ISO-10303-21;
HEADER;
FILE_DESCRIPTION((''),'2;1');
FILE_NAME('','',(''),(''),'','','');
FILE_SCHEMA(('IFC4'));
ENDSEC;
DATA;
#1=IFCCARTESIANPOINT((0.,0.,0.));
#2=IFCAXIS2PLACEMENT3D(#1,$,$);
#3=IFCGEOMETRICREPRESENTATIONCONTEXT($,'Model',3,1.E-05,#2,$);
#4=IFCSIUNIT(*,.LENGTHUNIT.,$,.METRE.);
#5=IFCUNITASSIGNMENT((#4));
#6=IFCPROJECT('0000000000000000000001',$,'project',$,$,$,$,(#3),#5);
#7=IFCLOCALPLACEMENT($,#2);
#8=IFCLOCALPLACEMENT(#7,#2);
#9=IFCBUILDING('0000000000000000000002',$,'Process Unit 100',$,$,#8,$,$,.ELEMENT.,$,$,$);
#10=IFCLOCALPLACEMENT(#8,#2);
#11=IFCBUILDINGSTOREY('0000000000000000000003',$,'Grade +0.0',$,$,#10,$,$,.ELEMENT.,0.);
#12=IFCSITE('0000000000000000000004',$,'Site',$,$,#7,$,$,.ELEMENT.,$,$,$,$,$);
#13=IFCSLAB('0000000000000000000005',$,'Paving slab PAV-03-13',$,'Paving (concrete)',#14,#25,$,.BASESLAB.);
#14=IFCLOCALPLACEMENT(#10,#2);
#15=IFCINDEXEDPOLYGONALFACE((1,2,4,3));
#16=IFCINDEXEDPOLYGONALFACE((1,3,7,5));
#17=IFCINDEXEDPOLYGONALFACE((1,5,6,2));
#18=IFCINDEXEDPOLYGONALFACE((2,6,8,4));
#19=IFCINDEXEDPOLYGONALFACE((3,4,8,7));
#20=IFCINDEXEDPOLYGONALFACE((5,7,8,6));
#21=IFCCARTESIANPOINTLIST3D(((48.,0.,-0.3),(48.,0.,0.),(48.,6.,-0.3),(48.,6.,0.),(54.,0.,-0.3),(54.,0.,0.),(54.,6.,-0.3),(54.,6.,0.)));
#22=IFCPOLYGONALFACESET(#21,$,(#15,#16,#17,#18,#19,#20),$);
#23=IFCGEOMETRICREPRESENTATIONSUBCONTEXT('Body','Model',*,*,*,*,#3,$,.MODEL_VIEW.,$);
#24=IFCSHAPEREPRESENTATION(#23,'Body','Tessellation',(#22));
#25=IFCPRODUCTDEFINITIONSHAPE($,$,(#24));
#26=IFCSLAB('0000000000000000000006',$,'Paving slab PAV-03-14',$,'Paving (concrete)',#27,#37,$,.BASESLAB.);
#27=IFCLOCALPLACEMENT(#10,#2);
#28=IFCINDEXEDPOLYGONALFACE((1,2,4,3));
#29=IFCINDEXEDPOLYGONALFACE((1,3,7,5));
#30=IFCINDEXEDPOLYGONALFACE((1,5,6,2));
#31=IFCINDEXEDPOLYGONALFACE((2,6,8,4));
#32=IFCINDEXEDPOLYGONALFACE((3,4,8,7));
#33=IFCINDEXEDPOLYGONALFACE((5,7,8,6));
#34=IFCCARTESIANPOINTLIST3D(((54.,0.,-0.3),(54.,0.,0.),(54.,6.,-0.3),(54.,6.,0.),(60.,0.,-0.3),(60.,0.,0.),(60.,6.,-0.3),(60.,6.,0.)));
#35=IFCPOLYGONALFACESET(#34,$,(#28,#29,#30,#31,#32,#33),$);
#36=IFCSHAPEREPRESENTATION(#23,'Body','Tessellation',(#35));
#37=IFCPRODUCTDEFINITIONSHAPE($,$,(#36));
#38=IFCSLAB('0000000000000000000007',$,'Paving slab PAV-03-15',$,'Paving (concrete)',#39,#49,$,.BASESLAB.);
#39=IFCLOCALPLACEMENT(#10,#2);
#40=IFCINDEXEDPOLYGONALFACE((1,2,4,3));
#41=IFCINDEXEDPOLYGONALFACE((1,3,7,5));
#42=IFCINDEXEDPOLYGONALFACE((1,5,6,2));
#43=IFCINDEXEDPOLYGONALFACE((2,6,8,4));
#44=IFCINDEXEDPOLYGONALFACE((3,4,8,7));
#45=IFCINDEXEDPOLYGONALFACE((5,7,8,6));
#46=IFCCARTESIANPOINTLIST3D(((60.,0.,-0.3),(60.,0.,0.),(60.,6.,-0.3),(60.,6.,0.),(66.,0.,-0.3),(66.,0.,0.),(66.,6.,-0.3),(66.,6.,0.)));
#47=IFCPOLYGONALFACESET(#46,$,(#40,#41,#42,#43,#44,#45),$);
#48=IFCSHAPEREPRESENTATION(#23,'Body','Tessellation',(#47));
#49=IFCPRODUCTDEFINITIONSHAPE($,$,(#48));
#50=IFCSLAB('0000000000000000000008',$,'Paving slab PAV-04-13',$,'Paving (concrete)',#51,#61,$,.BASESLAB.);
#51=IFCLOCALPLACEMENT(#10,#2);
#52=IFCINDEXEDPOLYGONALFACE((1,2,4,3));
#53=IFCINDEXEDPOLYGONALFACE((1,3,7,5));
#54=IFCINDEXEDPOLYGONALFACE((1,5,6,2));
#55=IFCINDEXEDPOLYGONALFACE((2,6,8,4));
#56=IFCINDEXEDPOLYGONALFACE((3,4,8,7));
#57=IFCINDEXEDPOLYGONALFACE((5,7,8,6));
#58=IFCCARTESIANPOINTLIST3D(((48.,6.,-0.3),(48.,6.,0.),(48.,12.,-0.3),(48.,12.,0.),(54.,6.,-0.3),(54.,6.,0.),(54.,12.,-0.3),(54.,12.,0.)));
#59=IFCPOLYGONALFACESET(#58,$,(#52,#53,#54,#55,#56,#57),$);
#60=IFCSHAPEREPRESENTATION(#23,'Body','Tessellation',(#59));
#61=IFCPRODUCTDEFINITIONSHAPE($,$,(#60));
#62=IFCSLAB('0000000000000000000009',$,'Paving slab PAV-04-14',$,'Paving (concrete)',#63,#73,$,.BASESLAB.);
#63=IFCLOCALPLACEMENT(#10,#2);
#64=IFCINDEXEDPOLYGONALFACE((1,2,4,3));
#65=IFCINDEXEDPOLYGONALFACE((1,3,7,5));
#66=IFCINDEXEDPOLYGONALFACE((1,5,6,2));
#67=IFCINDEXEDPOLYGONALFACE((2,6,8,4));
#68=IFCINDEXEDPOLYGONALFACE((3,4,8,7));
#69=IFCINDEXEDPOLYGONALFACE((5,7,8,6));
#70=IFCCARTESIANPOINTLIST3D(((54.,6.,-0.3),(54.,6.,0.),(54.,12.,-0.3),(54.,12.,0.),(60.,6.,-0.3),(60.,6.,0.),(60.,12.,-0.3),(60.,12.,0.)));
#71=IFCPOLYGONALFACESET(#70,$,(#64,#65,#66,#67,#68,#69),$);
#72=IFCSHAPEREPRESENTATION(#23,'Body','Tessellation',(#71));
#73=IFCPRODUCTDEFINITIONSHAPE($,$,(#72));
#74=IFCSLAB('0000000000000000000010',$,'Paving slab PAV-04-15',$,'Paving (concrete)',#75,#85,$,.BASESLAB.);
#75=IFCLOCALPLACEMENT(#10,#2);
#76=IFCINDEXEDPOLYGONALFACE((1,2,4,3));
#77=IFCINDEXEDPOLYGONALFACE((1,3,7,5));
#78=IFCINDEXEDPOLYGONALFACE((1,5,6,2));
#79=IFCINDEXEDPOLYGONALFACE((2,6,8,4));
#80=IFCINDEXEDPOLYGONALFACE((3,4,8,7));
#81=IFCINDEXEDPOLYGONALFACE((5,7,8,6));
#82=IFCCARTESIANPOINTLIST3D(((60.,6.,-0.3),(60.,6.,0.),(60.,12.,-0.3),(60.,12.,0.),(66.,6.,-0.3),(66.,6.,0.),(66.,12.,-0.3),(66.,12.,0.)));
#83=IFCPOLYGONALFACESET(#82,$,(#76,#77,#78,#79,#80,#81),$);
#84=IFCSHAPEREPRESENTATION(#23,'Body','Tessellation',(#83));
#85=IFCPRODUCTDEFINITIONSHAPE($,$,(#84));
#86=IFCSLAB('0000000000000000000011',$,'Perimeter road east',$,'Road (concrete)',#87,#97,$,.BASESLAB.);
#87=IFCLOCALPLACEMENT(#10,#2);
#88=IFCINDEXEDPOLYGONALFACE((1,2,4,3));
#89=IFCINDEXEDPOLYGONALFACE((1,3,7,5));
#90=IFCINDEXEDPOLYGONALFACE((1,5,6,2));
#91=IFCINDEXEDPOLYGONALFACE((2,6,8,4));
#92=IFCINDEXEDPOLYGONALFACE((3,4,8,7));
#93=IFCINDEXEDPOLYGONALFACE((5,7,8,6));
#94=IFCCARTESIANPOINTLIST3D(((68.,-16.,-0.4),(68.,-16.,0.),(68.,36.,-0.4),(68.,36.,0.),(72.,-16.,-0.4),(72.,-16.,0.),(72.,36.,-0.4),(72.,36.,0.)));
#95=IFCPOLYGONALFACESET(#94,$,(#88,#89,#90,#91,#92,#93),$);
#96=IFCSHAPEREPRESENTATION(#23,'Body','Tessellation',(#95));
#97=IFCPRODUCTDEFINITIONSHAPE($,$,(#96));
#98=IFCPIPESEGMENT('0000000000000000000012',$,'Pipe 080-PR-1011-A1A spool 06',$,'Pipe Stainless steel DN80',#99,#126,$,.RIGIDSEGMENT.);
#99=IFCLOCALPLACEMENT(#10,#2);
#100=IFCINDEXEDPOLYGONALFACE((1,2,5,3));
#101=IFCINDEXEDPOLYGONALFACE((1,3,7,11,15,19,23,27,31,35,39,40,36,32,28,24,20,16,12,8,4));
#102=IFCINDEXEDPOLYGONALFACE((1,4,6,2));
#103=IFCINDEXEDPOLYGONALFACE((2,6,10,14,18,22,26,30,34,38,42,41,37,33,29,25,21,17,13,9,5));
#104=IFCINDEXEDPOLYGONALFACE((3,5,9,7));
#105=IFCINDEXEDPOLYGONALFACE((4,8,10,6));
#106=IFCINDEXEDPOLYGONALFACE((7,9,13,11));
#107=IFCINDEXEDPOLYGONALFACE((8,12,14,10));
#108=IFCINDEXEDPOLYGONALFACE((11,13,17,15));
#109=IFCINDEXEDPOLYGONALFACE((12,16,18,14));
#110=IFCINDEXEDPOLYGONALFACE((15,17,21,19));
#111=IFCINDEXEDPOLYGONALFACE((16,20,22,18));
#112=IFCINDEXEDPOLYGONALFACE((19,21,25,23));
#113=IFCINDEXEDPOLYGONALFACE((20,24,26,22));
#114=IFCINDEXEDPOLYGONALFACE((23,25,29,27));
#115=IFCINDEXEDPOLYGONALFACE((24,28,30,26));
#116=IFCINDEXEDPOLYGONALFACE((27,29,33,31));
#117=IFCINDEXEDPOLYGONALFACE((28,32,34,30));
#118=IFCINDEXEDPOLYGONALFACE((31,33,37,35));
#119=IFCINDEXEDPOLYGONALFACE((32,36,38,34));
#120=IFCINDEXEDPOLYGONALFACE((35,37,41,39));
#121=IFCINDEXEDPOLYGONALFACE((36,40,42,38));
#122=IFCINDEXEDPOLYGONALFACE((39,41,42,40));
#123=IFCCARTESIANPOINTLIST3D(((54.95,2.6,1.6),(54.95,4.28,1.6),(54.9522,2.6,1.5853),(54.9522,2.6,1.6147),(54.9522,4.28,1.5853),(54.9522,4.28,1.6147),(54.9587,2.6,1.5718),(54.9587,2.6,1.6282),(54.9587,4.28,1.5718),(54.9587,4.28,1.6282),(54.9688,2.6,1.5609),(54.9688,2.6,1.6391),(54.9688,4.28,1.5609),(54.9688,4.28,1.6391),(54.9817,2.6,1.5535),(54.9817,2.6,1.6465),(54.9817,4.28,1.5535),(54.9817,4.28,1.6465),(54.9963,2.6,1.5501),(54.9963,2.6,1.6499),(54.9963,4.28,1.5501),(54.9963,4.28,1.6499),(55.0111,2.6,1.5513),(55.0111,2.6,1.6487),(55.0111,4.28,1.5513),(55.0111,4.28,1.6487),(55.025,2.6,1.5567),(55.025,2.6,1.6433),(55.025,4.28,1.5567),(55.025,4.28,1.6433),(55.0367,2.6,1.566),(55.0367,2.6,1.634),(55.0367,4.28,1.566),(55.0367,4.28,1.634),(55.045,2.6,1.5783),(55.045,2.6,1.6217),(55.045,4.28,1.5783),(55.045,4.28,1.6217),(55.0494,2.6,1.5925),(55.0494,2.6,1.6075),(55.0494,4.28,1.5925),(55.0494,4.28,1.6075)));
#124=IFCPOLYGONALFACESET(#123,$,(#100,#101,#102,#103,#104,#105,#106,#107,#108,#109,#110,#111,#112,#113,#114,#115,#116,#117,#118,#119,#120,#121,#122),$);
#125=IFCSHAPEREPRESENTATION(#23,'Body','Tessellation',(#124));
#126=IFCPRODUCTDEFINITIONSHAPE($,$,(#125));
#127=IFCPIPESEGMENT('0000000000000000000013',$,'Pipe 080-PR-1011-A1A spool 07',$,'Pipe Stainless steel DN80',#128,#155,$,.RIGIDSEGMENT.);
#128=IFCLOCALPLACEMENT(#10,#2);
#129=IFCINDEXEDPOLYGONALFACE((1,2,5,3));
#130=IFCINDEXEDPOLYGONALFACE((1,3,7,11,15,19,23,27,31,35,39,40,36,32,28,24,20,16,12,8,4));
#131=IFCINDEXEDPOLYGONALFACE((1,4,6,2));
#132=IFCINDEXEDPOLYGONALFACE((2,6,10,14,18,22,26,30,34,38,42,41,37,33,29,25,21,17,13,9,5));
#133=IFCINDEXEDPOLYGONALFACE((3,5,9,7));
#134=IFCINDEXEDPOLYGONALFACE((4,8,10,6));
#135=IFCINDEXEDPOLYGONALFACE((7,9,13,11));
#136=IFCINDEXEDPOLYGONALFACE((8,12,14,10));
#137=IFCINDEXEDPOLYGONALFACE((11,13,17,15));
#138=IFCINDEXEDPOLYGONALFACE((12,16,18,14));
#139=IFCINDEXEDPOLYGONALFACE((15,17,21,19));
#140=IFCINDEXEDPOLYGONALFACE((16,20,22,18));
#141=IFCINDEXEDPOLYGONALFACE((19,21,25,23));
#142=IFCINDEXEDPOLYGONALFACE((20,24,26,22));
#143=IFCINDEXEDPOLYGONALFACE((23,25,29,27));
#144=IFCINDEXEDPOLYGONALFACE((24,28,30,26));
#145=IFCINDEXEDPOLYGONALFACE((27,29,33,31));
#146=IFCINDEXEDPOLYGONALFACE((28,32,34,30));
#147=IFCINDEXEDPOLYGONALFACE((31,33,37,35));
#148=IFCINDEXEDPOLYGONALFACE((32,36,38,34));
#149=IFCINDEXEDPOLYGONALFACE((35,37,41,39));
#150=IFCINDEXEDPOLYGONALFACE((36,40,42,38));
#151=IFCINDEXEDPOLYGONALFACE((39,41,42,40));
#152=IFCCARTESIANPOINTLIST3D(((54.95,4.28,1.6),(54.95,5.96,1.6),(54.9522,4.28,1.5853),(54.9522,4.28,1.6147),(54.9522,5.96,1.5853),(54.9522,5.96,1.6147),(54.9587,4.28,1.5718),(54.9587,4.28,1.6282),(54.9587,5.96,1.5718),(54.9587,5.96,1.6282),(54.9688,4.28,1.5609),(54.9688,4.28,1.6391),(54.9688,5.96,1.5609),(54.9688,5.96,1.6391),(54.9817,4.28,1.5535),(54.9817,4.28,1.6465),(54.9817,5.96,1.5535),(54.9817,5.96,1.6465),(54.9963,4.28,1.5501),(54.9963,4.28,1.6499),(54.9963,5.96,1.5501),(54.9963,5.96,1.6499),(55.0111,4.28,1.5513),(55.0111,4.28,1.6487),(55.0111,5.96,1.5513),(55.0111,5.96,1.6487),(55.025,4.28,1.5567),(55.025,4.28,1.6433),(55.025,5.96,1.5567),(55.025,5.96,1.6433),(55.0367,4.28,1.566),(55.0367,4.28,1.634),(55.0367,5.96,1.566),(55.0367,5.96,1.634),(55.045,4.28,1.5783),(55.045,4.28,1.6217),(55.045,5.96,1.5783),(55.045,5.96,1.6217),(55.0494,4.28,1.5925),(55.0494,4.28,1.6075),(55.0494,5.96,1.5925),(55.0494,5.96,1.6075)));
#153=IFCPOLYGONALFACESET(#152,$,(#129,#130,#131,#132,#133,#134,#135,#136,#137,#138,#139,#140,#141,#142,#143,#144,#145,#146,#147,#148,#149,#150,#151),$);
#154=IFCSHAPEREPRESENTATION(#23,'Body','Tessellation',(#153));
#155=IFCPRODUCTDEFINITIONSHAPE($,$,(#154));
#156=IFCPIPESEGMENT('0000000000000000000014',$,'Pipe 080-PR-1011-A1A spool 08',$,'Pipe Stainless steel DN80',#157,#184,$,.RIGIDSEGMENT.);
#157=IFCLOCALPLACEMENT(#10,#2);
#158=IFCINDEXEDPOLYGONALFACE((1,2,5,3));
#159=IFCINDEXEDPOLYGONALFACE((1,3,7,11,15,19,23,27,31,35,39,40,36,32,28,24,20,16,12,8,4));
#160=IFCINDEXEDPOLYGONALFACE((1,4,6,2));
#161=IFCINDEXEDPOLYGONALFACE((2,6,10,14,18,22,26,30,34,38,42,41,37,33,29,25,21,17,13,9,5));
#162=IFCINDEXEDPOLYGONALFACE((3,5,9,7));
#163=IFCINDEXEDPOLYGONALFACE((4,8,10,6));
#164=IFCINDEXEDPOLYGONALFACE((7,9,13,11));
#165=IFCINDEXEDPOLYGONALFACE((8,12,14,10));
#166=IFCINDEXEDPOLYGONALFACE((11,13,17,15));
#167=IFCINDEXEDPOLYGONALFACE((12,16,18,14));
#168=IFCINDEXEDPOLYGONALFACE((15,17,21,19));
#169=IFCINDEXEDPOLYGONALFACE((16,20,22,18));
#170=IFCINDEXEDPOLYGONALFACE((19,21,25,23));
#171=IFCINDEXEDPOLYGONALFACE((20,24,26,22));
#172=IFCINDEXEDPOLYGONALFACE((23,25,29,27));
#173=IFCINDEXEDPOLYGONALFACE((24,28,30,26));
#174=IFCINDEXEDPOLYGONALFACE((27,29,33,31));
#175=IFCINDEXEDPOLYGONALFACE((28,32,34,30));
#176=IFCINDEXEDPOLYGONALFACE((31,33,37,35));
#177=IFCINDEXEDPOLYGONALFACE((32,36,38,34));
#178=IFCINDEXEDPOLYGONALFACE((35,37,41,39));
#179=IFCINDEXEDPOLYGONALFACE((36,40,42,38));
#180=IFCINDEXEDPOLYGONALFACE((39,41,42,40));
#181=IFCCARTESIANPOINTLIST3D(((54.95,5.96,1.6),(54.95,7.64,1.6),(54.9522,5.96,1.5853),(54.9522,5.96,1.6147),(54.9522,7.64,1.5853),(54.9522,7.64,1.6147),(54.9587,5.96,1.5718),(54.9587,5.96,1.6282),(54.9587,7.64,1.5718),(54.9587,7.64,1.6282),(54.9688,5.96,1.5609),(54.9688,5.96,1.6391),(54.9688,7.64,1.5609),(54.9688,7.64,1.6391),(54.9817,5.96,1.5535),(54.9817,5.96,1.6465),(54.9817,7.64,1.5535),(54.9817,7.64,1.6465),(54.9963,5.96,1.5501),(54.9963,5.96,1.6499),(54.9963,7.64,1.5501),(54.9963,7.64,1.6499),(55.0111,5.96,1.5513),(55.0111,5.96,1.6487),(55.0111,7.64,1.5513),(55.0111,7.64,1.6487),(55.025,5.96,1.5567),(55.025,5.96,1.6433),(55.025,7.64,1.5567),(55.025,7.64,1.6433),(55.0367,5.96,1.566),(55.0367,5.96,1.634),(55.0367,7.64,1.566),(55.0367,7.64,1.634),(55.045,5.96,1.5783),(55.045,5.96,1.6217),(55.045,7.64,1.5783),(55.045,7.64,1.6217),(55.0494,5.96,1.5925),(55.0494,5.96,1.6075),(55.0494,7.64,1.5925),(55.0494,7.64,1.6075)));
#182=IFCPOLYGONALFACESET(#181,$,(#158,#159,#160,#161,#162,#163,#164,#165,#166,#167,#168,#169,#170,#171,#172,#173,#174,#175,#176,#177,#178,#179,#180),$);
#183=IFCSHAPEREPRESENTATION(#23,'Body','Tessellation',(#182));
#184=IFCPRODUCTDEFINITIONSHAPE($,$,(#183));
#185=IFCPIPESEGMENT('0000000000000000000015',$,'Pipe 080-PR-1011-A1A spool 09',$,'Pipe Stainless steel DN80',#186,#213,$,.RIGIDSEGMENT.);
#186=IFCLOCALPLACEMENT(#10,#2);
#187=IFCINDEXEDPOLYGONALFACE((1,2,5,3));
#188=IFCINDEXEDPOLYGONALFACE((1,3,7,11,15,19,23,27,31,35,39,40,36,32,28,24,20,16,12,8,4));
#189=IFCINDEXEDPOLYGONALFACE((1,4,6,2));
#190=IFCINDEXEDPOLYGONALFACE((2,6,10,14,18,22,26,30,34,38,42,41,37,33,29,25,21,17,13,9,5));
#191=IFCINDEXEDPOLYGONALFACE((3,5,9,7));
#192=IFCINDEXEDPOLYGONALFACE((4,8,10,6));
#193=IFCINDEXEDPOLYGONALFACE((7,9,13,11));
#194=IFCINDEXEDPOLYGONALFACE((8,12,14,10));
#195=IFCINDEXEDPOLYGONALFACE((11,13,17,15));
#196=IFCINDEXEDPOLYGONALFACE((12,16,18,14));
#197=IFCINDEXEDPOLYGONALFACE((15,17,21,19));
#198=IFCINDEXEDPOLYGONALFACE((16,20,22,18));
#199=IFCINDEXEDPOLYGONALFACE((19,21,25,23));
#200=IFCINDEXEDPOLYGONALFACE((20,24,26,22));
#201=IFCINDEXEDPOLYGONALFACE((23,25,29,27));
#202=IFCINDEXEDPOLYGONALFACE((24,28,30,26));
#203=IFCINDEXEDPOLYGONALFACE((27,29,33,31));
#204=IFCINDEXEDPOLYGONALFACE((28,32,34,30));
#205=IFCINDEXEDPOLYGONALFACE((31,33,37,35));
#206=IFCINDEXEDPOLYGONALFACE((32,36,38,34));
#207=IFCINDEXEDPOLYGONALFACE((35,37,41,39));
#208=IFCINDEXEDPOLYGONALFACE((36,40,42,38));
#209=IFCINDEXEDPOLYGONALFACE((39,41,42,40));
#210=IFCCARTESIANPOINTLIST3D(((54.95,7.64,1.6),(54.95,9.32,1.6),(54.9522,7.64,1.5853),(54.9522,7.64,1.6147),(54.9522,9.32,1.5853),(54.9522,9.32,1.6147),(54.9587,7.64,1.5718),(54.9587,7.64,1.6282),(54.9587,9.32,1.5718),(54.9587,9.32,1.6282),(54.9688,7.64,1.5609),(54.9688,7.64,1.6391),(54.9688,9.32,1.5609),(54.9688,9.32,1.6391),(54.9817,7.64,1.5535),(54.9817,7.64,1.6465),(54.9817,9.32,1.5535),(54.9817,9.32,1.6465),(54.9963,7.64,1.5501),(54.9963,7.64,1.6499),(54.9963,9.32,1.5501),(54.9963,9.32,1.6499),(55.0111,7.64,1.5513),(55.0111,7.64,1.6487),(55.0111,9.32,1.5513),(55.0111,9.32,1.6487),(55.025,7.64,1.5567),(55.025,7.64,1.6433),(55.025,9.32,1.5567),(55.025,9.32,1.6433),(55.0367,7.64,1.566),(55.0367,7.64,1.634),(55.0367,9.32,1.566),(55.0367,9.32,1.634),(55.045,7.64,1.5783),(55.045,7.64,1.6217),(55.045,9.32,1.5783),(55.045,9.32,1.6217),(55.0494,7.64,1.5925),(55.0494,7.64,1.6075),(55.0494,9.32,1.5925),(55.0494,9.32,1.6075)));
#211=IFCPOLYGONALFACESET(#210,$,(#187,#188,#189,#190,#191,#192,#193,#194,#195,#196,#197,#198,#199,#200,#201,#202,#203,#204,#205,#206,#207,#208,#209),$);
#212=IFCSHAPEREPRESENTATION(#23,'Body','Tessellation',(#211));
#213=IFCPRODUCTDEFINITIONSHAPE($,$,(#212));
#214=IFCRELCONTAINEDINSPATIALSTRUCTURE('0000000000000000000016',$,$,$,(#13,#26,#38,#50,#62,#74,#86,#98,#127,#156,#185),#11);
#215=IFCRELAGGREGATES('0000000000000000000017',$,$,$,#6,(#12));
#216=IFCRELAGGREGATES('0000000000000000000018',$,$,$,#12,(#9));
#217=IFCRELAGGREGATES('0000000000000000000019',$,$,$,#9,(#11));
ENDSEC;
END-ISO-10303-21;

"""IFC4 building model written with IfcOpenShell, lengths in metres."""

from ifc_helpers import new_model, si_unit, frame, origin, place, context, subcontext, project, spatial, rectangle, circle, extrude, element, save


model = new_model("IFC4")

# Units and contexts
model_context = context("Model", 3, precision=1e-05, world=origin())
body_context = subcontext(model_context, "Body", "Model", "MODEL_VIEW")
ifc_project = project(units=[si_unit("LENGTHUNIT", "METRE")], contexts=[model_context])

# Site, building, storey
site_placement = place(None, origin())
site = spatial("IfcSite", under=ifc_project, at=site_placement, Name="Site", CompositionType="ELEMENT")
building_placement = place(site_placement, origin())
building = spatial("IfcBuilding", under=site, at=building_placement, Name="Process Unit 100", CompositionType="ELEMENT")
storey_placement = place(building_placement, origin())
storey = spatial("IfcBuildingStorey", under=building, at=storey_placement, Name="Grade +0.0", CompositionType="ELEMENT", Elevation=0.0)

# Slabs
for number, where, z_axis, x_axis, name in (
    (1, (51.0, 3.0, -0.3), (0.0, 0.0, 1.0), (1.0, 0.0, 0.0), "Paving slab PAV-03-13"),
    (2, (57.0, 3.0, -0.3), (0.0, 0.0, 1.0), (1.0, 0.0, 0.0), "Paving slab PAV-03-14"),
    (3, (63.0, 3.0, -0.3), (0.0, 0.0, 1.0), (1.0, 0.0, 0.0), "Paving slab PAV-03-15"),
    (4, (51.0, 9.0, -0.3), (0.0, 0.0, 1.0), (1.0, 0.0, 0.0), "Paving slab PAV-04-13"),
    (5, (57.0, 9.0, -0.3), (0.0, 0.0, 1.0), (1.0, 0.0, 0.0), "Paving slab PAV-04-14"),
    (6, (63.0, 9.0, -0.3), (0.0, 0.0, 1.0), (1.0, 0.0, 0.0), "Paving slab PAV-04-15"),
):
    element("IfcSlab", number, at=place(storey_placement, frame(where, z_axis=z_axis, x_axis=x_axis)), inside=storey, Name=name, ObjectType="Paving (concrete)", PredefinedType="BASESLAB", context=body_context, shape_type="SweptSolid", body=[
        extrude(rectangle(XDim=6.0, YDim=6.0), origin(), (0.0, 0.0, 1.0), 0.3),
    ])
slab_placement = place(storey_placement, frame((70.0, 10.0, -0.4), z_axis=(0.0, 0.0, 1.0), x_axis=(1.0, 0.0, 0.0)))
element("IfcSlab", 7, at=slab_placement, inside=storey, Name="Perimeter road east", ObjectType="Road (concrete)", PredefinedType="BASESLAB", context=body_context, shape_type="SweptSolid", body=[
    extrude(rectangle(XDim=4.0, YDim=52.0), origin(), (0.0, 0.0, 1.0), 0.4),
])

# Pipe segments
for number, where, z_axis, x_axis, name in (
    (8, (55.0, 2.6, 1.6), (0.0, 1.0, 0.0), (-1.0, 0.0, 0.0), "Pipe 080-PR-1011-A1A spool 06"),
    (9, (55.0, 4.28, 1.6), (0.0, 1.0, 0.0), (-1.0, 0.0, 0.0), "Pipe 080-PR-1011-A1A spool 07"),
    (10, (55.0, 5.96, 1.6), (0.0, 1.0, 0.0), (-1.0, 0.0, 0.0), "Pipe 080-PR-1011-A1A spool 08"),
    (11, (55.0, 7.64, 1.6), (0.0, 1.0, 0.0), (-1.0, 0.0, 0.0), "Pipe 080-PR-1011-A1A spool 09"),
):
    element("IfcPipeSegment", number, at=place(storey_placement, frame(where, z_axis=z_axis, x_axis=x_axis)), inside=storey, Name=name, ObjectType="Pipe Stainless steel DN80", PredefinedType="RIGIDSEGMENT", context=body_context, shape_type="SweptSolid", body=[
        extrude(circle(Radius=0.05), origin(), (0.0, 0.0, 1.0), 1.68),
    ])

save(model, "model.ifc")
